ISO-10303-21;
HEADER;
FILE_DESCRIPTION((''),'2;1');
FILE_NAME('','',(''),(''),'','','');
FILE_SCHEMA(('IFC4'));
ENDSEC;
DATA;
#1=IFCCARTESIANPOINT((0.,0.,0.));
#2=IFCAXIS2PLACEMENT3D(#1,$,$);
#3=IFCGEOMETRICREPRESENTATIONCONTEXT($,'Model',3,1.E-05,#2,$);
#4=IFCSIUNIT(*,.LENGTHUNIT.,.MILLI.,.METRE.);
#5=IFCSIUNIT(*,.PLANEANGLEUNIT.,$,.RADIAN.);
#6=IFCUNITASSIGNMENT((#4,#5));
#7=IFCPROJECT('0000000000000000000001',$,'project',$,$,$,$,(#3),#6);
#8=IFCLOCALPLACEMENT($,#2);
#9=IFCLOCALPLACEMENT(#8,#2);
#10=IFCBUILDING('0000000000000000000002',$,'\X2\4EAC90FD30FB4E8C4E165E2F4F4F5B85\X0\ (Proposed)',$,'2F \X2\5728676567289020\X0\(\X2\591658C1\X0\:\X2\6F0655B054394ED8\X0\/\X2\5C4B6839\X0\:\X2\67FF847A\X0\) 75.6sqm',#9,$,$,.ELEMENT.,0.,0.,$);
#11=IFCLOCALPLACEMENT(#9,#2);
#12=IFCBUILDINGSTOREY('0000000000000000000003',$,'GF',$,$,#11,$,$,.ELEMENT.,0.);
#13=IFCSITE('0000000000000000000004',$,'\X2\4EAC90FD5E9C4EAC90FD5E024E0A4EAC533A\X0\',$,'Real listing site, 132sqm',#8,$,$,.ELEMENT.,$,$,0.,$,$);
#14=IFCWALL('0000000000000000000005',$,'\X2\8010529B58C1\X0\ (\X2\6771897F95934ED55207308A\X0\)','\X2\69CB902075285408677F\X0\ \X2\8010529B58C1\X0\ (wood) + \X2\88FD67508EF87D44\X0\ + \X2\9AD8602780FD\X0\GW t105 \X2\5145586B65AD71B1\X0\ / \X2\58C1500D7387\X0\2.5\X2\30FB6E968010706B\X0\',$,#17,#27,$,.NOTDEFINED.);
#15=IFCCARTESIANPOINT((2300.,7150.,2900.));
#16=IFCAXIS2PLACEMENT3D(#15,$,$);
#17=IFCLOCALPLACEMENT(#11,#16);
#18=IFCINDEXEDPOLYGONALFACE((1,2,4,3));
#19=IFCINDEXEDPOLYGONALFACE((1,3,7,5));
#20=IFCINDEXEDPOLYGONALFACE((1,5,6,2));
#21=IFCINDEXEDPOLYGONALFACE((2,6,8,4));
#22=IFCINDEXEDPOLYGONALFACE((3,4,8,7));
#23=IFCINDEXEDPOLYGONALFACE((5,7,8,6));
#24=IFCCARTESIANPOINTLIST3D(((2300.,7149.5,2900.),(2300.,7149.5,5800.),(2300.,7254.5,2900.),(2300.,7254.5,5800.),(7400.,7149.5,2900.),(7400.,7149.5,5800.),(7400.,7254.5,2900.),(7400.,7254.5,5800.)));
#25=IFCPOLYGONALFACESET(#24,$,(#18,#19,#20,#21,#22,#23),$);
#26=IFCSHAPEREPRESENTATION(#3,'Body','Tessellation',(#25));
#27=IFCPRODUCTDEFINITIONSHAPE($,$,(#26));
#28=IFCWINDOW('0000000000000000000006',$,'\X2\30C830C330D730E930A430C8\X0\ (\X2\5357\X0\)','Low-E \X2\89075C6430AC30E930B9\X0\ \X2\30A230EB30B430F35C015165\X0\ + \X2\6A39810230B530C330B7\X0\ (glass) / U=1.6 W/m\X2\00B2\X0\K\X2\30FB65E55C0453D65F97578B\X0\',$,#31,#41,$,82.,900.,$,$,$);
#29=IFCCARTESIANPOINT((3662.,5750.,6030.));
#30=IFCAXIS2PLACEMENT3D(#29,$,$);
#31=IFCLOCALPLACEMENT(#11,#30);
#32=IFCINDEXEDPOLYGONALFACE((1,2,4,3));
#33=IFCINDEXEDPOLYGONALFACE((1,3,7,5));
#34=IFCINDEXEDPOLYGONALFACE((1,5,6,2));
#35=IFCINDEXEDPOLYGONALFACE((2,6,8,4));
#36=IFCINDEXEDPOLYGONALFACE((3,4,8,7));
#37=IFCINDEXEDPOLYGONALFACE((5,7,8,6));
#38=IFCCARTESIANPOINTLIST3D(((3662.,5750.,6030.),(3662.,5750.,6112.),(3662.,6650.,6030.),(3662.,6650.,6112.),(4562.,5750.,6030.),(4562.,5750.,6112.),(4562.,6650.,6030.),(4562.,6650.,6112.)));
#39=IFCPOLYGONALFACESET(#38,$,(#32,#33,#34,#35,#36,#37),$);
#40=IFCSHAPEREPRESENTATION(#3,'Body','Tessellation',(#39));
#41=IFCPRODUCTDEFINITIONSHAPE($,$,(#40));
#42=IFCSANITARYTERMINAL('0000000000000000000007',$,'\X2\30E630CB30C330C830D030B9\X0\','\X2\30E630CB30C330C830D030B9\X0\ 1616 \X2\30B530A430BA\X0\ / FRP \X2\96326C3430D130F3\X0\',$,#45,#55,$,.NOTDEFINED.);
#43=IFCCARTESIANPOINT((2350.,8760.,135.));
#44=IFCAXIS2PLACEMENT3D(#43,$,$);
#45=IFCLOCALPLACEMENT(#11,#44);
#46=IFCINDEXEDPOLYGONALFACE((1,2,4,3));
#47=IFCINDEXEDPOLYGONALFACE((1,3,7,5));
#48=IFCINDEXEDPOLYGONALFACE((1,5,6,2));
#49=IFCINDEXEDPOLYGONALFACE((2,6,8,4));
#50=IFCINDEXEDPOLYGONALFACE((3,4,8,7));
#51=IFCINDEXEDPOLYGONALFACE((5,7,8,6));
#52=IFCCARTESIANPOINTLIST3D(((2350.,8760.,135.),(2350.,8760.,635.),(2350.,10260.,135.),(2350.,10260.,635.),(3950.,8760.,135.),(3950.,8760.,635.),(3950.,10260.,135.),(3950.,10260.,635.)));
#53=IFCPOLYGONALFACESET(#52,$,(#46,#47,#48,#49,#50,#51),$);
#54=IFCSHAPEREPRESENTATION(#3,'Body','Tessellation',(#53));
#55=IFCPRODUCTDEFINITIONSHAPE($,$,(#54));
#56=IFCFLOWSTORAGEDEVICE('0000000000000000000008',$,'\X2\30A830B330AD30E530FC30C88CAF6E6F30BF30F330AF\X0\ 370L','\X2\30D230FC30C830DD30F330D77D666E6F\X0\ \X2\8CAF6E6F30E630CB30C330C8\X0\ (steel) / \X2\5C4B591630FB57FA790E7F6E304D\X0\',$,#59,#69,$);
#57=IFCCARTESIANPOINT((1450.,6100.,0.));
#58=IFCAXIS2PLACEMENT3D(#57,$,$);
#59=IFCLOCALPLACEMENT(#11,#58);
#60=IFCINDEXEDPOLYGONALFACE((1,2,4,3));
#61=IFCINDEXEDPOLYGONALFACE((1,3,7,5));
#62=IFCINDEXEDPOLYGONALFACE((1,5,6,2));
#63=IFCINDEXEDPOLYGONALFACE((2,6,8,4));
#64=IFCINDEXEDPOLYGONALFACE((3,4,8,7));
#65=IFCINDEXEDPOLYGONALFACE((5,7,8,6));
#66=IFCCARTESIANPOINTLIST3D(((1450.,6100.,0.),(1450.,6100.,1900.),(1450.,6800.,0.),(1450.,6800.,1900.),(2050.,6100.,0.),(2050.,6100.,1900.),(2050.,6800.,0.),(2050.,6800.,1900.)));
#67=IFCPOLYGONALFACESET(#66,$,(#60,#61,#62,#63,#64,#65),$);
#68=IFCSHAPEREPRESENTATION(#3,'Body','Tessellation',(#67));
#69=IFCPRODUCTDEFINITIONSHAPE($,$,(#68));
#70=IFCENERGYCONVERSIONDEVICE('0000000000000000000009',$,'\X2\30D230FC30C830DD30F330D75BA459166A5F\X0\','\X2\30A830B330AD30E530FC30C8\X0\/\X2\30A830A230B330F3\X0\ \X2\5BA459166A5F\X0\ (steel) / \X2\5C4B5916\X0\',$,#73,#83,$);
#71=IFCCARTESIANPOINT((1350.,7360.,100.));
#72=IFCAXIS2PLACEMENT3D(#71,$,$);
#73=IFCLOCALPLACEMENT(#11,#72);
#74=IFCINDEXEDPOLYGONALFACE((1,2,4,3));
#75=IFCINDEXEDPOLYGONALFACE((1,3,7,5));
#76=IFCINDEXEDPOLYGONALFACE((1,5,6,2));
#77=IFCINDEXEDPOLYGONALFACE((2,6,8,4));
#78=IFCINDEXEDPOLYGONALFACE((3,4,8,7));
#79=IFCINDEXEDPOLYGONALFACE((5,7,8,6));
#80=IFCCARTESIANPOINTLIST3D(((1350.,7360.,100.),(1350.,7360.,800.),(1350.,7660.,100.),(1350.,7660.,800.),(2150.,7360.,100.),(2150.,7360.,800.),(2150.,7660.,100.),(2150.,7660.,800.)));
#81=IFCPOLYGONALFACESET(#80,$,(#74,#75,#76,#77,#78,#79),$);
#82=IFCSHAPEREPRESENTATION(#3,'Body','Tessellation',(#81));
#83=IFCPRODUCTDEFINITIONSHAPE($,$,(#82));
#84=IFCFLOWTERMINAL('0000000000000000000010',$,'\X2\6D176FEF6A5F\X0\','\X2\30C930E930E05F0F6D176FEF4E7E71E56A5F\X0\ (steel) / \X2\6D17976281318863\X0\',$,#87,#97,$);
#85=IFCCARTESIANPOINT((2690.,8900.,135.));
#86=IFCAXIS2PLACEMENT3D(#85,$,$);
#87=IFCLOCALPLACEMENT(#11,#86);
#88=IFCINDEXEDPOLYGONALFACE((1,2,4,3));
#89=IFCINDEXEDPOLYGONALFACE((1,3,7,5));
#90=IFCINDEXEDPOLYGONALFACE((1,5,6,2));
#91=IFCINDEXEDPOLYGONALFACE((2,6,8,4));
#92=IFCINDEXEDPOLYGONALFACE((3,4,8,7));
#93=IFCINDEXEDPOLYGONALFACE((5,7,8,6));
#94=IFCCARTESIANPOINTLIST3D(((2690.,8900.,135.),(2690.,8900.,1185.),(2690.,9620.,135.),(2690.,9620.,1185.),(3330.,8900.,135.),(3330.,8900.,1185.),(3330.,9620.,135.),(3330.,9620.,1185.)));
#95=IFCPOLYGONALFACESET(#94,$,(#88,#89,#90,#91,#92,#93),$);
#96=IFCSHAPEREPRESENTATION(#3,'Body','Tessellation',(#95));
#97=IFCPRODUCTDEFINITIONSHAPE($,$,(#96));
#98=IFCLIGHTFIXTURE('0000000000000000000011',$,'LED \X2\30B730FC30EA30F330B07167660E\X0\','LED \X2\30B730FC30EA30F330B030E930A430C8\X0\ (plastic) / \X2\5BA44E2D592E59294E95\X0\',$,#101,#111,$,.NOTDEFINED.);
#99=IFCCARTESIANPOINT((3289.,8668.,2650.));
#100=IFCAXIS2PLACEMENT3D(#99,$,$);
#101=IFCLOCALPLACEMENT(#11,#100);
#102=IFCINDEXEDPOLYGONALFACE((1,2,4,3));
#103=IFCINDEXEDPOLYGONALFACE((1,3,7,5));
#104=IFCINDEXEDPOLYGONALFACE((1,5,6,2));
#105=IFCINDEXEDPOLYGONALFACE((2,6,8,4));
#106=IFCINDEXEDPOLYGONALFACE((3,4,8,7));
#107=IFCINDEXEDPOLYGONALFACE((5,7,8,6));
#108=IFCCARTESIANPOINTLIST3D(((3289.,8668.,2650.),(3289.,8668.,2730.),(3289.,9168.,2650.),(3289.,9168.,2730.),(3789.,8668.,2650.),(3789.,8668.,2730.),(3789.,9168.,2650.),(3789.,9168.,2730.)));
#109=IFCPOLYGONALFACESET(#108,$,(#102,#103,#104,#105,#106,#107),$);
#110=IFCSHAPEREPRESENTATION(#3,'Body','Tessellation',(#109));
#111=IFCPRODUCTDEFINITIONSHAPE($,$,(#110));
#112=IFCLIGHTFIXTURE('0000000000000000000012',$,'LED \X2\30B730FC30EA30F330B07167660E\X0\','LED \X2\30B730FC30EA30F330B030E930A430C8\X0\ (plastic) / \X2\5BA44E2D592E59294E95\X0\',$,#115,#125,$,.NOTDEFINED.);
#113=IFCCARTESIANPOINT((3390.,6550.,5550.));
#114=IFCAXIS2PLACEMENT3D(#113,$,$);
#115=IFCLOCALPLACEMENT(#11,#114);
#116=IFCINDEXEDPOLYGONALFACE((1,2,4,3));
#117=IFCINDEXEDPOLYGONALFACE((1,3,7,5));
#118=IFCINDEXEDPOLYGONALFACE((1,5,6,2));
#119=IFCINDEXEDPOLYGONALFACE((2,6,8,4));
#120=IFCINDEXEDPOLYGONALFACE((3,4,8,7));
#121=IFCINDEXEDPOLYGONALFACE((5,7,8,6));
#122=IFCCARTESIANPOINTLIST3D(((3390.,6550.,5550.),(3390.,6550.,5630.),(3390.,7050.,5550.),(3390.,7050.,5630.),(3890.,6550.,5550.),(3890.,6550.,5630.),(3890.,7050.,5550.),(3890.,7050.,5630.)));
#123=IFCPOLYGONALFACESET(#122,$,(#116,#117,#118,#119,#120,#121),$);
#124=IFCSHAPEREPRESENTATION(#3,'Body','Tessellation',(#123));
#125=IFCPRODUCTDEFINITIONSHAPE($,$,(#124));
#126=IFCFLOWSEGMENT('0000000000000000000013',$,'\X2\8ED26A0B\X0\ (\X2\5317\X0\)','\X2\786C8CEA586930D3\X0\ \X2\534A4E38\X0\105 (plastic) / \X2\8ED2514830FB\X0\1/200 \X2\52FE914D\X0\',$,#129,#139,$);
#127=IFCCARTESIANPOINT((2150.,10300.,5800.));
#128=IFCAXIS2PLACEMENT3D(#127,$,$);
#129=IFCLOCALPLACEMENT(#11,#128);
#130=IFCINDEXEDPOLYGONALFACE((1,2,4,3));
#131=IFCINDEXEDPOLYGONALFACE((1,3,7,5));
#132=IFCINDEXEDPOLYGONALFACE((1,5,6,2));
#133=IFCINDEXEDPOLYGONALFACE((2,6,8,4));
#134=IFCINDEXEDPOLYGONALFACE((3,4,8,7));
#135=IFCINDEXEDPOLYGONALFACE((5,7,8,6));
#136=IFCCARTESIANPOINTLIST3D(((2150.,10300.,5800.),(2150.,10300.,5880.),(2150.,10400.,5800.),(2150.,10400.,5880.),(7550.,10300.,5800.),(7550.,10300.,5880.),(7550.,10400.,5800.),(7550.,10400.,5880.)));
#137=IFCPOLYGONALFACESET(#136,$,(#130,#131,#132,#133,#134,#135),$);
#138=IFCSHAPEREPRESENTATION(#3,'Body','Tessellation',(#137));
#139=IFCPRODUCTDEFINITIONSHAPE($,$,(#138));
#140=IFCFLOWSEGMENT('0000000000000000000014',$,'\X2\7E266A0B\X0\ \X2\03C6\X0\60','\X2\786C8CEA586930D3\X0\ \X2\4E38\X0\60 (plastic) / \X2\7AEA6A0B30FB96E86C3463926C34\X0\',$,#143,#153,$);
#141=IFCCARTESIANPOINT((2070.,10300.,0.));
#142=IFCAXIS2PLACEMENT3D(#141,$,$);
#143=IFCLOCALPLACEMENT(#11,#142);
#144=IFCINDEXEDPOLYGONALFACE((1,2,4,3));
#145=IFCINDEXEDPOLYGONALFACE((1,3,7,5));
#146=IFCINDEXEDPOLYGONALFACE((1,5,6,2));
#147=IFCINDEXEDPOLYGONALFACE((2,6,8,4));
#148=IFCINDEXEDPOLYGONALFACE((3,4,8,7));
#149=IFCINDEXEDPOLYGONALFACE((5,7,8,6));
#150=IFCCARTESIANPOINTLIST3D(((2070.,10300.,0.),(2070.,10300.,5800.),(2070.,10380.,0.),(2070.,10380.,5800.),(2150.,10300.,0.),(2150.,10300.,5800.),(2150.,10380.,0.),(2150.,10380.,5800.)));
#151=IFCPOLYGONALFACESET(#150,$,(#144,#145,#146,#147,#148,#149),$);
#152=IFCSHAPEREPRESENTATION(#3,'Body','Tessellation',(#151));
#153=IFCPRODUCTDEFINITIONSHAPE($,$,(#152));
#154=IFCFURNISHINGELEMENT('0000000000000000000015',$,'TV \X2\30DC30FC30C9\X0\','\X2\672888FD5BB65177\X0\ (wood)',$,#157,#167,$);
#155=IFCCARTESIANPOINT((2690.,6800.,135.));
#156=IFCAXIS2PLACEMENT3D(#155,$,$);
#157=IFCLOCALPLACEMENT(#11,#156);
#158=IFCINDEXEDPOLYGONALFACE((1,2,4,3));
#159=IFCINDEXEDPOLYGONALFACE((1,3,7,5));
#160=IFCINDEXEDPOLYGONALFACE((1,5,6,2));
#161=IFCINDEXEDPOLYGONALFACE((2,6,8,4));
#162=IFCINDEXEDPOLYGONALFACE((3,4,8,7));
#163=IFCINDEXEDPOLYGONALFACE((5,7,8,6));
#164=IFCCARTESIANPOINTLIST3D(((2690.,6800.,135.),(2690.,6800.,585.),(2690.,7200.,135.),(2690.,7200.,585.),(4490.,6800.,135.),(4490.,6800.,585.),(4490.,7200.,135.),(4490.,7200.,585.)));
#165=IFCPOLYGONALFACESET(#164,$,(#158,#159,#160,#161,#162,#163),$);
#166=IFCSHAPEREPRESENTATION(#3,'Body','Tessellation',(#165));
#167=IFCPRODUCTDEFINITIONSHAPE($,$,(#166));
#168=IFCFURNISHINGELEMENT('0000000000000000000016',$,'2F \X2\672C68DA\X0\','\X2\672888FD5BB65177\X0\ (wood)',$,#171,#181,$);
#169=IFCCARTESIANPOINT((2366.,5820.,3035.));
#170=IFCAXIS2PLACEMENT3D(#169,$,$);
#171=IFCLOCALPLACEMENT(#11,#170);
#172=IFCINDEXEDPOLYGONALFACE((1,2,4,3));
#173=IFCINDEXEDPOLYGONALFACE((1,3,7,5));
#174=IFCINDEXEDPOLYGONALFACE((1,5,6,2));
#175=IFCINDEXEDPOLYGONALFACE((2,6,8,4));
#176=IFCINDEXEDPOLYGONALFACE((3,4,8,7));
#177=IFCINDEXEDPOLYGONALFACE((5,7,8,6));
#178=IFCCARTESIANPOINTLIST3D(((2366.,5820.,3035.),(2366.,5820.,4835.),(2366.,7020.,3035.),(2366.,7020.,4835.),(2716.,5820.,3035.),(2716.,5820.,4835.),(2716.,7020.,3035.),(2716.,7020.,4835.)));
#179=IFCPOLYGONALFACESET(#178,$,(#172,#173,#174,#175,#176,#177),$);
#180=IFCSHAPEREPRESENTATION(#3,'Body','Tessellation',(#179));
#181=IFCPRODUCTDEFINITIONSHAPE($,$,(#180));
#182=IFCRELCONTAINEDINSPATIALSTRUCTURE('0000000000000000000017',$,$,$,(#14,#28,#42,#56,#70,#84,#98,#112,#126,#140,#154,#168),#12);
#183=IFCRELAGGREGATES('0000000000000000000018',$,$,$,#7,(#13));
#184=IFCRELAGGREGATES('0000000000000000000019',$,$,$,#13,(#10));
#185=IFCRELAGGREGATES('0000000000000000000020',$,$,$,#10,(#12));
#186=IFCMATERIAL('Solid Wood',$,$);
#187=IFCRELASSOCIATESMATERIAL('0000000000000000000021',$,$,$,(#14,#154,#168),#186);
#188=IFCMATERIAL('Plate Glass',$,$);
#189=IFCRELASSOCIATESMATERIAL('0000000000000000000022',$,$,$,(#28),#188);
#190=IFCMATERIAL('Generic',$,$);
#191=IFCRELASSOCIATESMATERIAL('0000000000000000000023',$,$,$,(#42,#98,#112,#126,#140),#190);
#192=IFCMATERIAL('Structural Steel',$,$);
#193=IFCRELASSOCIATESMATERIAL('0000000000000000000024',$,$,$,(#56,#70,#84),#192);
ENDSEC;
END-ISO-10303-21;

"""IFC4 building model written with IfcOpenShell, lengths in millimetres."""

from ifc_helpers import new_model, si_unit, frame, frame_2d, origin, place, context, project, spatial, rectangle, extrude, material, element, save


model = new_model("IFC4")

# Units and contexts
model_context = context("Model", 3, precision=1e-05, world=origin())
ifc_project = project(units=[si_unit("LENGTHUNIT", "METRE", prefix="MILLI"), si_unit("PLANEANGLEUNIT", "RADIAN")], contexts=[model_context])

# Site, building, storey
site_placement = place(None, origin())
site = spatial("IfcSite", under=ifc_project, at=site_placement, Name="京都府京都市上京区", ObjectType="Real listing site, 132sqm", CompositionType="ELEMENT", RefElevation=0.0)
building_placement = place(site_placement, origin())
building = spatial("IfcBuilding", under=site, at=building_placement, Name="京都・二世帯住宅 (Proposed)", ObjectType="2F 在来木造(外壁:漆喰吹付/屋根:柿葺) 75.6sqm", CompositionType="ELEMENT", ElevationOfRefHeight=0.0, ElevationOfTerrain=0.0)
storey_placement = place(building_placement, origin())
storey = spatial("IfcBuildingStorey", under=building, at=storey_placement, Name="GF", CompositionType="ELEMENT", Elevation=0.0)

# Shared definitions
ifc_material_1 = material(Name="Solid Wood")

# Shared definitions
ifc_material_2 = material(Name="Plate Glass")

# Wall
wall_1_placement = place(storey_placement, frame((2300.0, 7150.0, 2900.0)))
element("IfcWall", 1, at=wall_1_placement, inside=storey, material=ifc_material_1, Name="耐力壁 (東西間仕切り)", Description="構造用合板 耐力壁 (wood) + 製材軸組 + 高性能GW t105 充填断熱 / 壁倍率2.5・準耐火", PredefinedType="NOTDEFINED", context=model_context, shape_type="SweptSolid", body=[
    extrude(rectangle(XDim=5100.0, YDim=105.0, at=frame_2d((2550.0, 52.0))), frame((2300.0, 7150.0, 2900.0)), (0.0, 0.0, 1.0), 2900.0),
])

# Window
window_1_placement = place(storey_placement, frame((3662.0, 5750.0, 6030.0)))
element("IfcWindow", 2, at=window_1_placement, inside=storey, material=ifc_material_2, Name="トップライト (南)", Description="Low-E 複層ガラス アルゴン封入 + 樹脂サッシ (glass) / U=1.6 W/m²K・日射取得型", OverallHeight=82.0, OverallWidth=900.0, context=model_context, shape_type="SweptSolid", body=[
    extrude(rectangle(XDim=900.0, YDim=900.0, at=frame_2d((450.0, 450.0))), frame((3662.0, 5750.0, 6030.0)), (0.0, 0.0, 1.0), 82.0),
])

# Sanitary terminal
ifc_material_3 = material(Name="Generic")
sanitary_terminal_placement = place(storey_placement, frame((2350.0, 8760.0, 135.0)))
element("IfcSanitaryTerminal", 3, at=sanitary_terminal_placement, inside=storey, material=ifc_material_3, Name="ユニットバス", Description="ユニットバス 1616 サイズ / FRP 防水パン", PredefinedType="NOTDEFINED", context=model_context, shape_type="SweptSolid", body=[
    extrude(rectangle(XDim=1600.0, YDim=1500.0, at=frame_2d((800.0, 750.0))), frame((2350.0, 8760.0, 135.0)), (0.0, 0.0, 1.0), 500.0),
])

# Flow storage device
ifc_material_4 = material(Name="Structural Steel")
flow_storage_device_placement = place(storey_placement, frame((1450.0, 6100.0, 0.0)))
element("IfcFlowStorageDevice", 4, at=flow_storage_device_placement, inside=storey, material=ifc_material_4, Name="エコキュート貯湯タンク 370L", Description="ヒートポンプ給湯 貯湯ユニット (steel) / 屋外・基礎置き", context=model_context, shape_type="SweptSolid", body=[
    extrude(rectangle(XDim=600.0, YDim=700.0, at=frame_2d((300.0, 350.0))), frame((1450.0, 6100.0, 0.0)), (0.0, 0.0, 1.0), 1900.0),
])

# Energy conversion device
energy_conversion_device_placement = place(storey_placement, frame((1350.0, 7360.0, 100.0)))
element("IfcEnergyConversionDevice", 5, at=energy_conversion_device_placement, inside=storey, material=ifc_material_4, Name="ヒートポンプ室外機", Description="エコキュート/エアコン 室外機 (steel) / 屋外", context=model_context, shape_type="SweptSolid", body=[
    extrude(rectangle(XDim=800.0, YDim=300.0, at=frame_2d((400.0, 150.0))), frame((1350.0, 7360.0, 100.0)), (0.0, 0.0, 1.0), 700.0),
])

# Flow terminal
flow_terminal_placement = place(storey_placement, frame((2690.0, 8900.0, 135.0)))
element("IfcFlowTerminal", 6, at=flow_terminal_placement, inside=storey, material=ifc_material_4, Name="洗濯機", Description="ドラム式洗濯乾燥機 (steel) / 洗面脱衣", context=model_context, shape_type="SweptSolid", body=[
    extrude(rectangle(XDim=640.0, YDim=720.0, at=frame_2d((320.0, 360.0))), frame((2690.0, 8900.0, 135.0)), (0.0, 0.0, 1.0), 1050.0),
])

# Light fixtures
light_fixture_1_placement = place(storey_placement, frame((3289.0, 8668.0, 2650.0)))
element("IfcLightFixture", 7, at=light_fixture_1_placement, inside=storey, material=ifc_material_3, Name="LED シーリング照明", Description="LED シーリングライト (plastic) / 室中央天井", PredefinedType="NOTDEFINED", context=model_context, shape_type="SweptSolid", body=[
    extrude(rectangle(XDim=500.0, YDim=500.0, at=frame_2d((250.0, 250.0))), frame((3289.0, 8668.0, 2650.0)), (0.0, 0.0, 1.0), 80.0),
])
light_fixture_2_placement = place(storey_placement, frame((3390.0, 6550.0, 5550.0)))
element("IfcLightFixture", 8, at=light_fixture_2_placement, inside=storey, material=ifc_material_3, Name="LED シーリング照明", Description="LED シーリングライト (plastic) / 室中央天井", PredefinedType="NOTDEFINED", context=model_context, shape_type="SweptSolid", body=[
    extrude(rectangle(XDim=500.0, YDim=500.0, at=frame_2d((250.0, 250.0))), frame((3390.0, 6550.0, 5550.0)), (0.0, 0.0, 1.0), 80.0),
])

# Flow segments
flow_segment_1_placement = place(storey_placement, frame((2150.0, 10300.0, 5800.0)))
element("IfcFlowSegment", 9, at=flow_segment_1_placement, inside=storey, material=ifc_material_3, Name="軒樋 (北)", Description="硬質塩ビ 半丸105 (plastic) / 軒先・1/200 勾配", context=model_context, shape_type="SweptSolid", body=[
    extrude(rectangle(XDim=5400.0, YDim=100.0, at=frame_2d((2700.0, 50.0))), frame((2150.0, 10300.0, 5800.0)), (0.0, 0.0, 1.0), 80.0),
])
flow_segment_2_placement = place(storey_placement, frame((2070.0, 10300.0, 0.0)))
element("IfcFlowSegment", 10, at=flow_segment_2_placement, inside=storey, material=ifc_material_3, Name="縦樋 φ60", Description="硬質塩ビ 丸60 (plastic) / 竪樋・雨水排水", context=model_context, shape_type="SweptSolid", body=[
    extrude(rectangle(XDim=80.0, YDim=80.0, at=frame_2d((40.0, 40.0))), frame((2070.0, 10300.0, 0.0)), (0.0, 0.0, 1.0), 5800.0),
])

# Furnishing elements
furnishing_1_placement = place(storey_placement, frame((2690.0, 6800.0, 135.0)))
element("IfcFurnishingElement", 11, at=furnishing_1_placement, inside=storey, material=ifc_material_1, Name="TV ボード", Description="木製家具 (wood)", context=model_context, shape_type="SweptSolid", body=[
    extrude(rectangle(XDim=1800.0, YDim=400.0, at=frame_2d((900.0, 200.0))), frame((2690.0, 6800.0, 135.0)), (0.0, 0.0, 1.0), 450.0),
])
furnishing_2_placement = place(storey_placement, frame((2366.0, 5820.0, 3035.0)))
element("IfcFurnishingElement", 12, at=furnishing_2_placement, inside=storey, material=ifc_material_1, Name="2F 本棚", Description="木製家具 (wood)", context=model_context, shape_type="SweptSolid", body=[
    extrude(rectangle(XDim=350.0, YDim=1200.0, at=frame_2d((175.0, 600.0))), frame((2366.0, 5820.0, 3035.0)), (0.0, 0.0, 1.0), 1800.0),
])

save(model, "model.ifc")
